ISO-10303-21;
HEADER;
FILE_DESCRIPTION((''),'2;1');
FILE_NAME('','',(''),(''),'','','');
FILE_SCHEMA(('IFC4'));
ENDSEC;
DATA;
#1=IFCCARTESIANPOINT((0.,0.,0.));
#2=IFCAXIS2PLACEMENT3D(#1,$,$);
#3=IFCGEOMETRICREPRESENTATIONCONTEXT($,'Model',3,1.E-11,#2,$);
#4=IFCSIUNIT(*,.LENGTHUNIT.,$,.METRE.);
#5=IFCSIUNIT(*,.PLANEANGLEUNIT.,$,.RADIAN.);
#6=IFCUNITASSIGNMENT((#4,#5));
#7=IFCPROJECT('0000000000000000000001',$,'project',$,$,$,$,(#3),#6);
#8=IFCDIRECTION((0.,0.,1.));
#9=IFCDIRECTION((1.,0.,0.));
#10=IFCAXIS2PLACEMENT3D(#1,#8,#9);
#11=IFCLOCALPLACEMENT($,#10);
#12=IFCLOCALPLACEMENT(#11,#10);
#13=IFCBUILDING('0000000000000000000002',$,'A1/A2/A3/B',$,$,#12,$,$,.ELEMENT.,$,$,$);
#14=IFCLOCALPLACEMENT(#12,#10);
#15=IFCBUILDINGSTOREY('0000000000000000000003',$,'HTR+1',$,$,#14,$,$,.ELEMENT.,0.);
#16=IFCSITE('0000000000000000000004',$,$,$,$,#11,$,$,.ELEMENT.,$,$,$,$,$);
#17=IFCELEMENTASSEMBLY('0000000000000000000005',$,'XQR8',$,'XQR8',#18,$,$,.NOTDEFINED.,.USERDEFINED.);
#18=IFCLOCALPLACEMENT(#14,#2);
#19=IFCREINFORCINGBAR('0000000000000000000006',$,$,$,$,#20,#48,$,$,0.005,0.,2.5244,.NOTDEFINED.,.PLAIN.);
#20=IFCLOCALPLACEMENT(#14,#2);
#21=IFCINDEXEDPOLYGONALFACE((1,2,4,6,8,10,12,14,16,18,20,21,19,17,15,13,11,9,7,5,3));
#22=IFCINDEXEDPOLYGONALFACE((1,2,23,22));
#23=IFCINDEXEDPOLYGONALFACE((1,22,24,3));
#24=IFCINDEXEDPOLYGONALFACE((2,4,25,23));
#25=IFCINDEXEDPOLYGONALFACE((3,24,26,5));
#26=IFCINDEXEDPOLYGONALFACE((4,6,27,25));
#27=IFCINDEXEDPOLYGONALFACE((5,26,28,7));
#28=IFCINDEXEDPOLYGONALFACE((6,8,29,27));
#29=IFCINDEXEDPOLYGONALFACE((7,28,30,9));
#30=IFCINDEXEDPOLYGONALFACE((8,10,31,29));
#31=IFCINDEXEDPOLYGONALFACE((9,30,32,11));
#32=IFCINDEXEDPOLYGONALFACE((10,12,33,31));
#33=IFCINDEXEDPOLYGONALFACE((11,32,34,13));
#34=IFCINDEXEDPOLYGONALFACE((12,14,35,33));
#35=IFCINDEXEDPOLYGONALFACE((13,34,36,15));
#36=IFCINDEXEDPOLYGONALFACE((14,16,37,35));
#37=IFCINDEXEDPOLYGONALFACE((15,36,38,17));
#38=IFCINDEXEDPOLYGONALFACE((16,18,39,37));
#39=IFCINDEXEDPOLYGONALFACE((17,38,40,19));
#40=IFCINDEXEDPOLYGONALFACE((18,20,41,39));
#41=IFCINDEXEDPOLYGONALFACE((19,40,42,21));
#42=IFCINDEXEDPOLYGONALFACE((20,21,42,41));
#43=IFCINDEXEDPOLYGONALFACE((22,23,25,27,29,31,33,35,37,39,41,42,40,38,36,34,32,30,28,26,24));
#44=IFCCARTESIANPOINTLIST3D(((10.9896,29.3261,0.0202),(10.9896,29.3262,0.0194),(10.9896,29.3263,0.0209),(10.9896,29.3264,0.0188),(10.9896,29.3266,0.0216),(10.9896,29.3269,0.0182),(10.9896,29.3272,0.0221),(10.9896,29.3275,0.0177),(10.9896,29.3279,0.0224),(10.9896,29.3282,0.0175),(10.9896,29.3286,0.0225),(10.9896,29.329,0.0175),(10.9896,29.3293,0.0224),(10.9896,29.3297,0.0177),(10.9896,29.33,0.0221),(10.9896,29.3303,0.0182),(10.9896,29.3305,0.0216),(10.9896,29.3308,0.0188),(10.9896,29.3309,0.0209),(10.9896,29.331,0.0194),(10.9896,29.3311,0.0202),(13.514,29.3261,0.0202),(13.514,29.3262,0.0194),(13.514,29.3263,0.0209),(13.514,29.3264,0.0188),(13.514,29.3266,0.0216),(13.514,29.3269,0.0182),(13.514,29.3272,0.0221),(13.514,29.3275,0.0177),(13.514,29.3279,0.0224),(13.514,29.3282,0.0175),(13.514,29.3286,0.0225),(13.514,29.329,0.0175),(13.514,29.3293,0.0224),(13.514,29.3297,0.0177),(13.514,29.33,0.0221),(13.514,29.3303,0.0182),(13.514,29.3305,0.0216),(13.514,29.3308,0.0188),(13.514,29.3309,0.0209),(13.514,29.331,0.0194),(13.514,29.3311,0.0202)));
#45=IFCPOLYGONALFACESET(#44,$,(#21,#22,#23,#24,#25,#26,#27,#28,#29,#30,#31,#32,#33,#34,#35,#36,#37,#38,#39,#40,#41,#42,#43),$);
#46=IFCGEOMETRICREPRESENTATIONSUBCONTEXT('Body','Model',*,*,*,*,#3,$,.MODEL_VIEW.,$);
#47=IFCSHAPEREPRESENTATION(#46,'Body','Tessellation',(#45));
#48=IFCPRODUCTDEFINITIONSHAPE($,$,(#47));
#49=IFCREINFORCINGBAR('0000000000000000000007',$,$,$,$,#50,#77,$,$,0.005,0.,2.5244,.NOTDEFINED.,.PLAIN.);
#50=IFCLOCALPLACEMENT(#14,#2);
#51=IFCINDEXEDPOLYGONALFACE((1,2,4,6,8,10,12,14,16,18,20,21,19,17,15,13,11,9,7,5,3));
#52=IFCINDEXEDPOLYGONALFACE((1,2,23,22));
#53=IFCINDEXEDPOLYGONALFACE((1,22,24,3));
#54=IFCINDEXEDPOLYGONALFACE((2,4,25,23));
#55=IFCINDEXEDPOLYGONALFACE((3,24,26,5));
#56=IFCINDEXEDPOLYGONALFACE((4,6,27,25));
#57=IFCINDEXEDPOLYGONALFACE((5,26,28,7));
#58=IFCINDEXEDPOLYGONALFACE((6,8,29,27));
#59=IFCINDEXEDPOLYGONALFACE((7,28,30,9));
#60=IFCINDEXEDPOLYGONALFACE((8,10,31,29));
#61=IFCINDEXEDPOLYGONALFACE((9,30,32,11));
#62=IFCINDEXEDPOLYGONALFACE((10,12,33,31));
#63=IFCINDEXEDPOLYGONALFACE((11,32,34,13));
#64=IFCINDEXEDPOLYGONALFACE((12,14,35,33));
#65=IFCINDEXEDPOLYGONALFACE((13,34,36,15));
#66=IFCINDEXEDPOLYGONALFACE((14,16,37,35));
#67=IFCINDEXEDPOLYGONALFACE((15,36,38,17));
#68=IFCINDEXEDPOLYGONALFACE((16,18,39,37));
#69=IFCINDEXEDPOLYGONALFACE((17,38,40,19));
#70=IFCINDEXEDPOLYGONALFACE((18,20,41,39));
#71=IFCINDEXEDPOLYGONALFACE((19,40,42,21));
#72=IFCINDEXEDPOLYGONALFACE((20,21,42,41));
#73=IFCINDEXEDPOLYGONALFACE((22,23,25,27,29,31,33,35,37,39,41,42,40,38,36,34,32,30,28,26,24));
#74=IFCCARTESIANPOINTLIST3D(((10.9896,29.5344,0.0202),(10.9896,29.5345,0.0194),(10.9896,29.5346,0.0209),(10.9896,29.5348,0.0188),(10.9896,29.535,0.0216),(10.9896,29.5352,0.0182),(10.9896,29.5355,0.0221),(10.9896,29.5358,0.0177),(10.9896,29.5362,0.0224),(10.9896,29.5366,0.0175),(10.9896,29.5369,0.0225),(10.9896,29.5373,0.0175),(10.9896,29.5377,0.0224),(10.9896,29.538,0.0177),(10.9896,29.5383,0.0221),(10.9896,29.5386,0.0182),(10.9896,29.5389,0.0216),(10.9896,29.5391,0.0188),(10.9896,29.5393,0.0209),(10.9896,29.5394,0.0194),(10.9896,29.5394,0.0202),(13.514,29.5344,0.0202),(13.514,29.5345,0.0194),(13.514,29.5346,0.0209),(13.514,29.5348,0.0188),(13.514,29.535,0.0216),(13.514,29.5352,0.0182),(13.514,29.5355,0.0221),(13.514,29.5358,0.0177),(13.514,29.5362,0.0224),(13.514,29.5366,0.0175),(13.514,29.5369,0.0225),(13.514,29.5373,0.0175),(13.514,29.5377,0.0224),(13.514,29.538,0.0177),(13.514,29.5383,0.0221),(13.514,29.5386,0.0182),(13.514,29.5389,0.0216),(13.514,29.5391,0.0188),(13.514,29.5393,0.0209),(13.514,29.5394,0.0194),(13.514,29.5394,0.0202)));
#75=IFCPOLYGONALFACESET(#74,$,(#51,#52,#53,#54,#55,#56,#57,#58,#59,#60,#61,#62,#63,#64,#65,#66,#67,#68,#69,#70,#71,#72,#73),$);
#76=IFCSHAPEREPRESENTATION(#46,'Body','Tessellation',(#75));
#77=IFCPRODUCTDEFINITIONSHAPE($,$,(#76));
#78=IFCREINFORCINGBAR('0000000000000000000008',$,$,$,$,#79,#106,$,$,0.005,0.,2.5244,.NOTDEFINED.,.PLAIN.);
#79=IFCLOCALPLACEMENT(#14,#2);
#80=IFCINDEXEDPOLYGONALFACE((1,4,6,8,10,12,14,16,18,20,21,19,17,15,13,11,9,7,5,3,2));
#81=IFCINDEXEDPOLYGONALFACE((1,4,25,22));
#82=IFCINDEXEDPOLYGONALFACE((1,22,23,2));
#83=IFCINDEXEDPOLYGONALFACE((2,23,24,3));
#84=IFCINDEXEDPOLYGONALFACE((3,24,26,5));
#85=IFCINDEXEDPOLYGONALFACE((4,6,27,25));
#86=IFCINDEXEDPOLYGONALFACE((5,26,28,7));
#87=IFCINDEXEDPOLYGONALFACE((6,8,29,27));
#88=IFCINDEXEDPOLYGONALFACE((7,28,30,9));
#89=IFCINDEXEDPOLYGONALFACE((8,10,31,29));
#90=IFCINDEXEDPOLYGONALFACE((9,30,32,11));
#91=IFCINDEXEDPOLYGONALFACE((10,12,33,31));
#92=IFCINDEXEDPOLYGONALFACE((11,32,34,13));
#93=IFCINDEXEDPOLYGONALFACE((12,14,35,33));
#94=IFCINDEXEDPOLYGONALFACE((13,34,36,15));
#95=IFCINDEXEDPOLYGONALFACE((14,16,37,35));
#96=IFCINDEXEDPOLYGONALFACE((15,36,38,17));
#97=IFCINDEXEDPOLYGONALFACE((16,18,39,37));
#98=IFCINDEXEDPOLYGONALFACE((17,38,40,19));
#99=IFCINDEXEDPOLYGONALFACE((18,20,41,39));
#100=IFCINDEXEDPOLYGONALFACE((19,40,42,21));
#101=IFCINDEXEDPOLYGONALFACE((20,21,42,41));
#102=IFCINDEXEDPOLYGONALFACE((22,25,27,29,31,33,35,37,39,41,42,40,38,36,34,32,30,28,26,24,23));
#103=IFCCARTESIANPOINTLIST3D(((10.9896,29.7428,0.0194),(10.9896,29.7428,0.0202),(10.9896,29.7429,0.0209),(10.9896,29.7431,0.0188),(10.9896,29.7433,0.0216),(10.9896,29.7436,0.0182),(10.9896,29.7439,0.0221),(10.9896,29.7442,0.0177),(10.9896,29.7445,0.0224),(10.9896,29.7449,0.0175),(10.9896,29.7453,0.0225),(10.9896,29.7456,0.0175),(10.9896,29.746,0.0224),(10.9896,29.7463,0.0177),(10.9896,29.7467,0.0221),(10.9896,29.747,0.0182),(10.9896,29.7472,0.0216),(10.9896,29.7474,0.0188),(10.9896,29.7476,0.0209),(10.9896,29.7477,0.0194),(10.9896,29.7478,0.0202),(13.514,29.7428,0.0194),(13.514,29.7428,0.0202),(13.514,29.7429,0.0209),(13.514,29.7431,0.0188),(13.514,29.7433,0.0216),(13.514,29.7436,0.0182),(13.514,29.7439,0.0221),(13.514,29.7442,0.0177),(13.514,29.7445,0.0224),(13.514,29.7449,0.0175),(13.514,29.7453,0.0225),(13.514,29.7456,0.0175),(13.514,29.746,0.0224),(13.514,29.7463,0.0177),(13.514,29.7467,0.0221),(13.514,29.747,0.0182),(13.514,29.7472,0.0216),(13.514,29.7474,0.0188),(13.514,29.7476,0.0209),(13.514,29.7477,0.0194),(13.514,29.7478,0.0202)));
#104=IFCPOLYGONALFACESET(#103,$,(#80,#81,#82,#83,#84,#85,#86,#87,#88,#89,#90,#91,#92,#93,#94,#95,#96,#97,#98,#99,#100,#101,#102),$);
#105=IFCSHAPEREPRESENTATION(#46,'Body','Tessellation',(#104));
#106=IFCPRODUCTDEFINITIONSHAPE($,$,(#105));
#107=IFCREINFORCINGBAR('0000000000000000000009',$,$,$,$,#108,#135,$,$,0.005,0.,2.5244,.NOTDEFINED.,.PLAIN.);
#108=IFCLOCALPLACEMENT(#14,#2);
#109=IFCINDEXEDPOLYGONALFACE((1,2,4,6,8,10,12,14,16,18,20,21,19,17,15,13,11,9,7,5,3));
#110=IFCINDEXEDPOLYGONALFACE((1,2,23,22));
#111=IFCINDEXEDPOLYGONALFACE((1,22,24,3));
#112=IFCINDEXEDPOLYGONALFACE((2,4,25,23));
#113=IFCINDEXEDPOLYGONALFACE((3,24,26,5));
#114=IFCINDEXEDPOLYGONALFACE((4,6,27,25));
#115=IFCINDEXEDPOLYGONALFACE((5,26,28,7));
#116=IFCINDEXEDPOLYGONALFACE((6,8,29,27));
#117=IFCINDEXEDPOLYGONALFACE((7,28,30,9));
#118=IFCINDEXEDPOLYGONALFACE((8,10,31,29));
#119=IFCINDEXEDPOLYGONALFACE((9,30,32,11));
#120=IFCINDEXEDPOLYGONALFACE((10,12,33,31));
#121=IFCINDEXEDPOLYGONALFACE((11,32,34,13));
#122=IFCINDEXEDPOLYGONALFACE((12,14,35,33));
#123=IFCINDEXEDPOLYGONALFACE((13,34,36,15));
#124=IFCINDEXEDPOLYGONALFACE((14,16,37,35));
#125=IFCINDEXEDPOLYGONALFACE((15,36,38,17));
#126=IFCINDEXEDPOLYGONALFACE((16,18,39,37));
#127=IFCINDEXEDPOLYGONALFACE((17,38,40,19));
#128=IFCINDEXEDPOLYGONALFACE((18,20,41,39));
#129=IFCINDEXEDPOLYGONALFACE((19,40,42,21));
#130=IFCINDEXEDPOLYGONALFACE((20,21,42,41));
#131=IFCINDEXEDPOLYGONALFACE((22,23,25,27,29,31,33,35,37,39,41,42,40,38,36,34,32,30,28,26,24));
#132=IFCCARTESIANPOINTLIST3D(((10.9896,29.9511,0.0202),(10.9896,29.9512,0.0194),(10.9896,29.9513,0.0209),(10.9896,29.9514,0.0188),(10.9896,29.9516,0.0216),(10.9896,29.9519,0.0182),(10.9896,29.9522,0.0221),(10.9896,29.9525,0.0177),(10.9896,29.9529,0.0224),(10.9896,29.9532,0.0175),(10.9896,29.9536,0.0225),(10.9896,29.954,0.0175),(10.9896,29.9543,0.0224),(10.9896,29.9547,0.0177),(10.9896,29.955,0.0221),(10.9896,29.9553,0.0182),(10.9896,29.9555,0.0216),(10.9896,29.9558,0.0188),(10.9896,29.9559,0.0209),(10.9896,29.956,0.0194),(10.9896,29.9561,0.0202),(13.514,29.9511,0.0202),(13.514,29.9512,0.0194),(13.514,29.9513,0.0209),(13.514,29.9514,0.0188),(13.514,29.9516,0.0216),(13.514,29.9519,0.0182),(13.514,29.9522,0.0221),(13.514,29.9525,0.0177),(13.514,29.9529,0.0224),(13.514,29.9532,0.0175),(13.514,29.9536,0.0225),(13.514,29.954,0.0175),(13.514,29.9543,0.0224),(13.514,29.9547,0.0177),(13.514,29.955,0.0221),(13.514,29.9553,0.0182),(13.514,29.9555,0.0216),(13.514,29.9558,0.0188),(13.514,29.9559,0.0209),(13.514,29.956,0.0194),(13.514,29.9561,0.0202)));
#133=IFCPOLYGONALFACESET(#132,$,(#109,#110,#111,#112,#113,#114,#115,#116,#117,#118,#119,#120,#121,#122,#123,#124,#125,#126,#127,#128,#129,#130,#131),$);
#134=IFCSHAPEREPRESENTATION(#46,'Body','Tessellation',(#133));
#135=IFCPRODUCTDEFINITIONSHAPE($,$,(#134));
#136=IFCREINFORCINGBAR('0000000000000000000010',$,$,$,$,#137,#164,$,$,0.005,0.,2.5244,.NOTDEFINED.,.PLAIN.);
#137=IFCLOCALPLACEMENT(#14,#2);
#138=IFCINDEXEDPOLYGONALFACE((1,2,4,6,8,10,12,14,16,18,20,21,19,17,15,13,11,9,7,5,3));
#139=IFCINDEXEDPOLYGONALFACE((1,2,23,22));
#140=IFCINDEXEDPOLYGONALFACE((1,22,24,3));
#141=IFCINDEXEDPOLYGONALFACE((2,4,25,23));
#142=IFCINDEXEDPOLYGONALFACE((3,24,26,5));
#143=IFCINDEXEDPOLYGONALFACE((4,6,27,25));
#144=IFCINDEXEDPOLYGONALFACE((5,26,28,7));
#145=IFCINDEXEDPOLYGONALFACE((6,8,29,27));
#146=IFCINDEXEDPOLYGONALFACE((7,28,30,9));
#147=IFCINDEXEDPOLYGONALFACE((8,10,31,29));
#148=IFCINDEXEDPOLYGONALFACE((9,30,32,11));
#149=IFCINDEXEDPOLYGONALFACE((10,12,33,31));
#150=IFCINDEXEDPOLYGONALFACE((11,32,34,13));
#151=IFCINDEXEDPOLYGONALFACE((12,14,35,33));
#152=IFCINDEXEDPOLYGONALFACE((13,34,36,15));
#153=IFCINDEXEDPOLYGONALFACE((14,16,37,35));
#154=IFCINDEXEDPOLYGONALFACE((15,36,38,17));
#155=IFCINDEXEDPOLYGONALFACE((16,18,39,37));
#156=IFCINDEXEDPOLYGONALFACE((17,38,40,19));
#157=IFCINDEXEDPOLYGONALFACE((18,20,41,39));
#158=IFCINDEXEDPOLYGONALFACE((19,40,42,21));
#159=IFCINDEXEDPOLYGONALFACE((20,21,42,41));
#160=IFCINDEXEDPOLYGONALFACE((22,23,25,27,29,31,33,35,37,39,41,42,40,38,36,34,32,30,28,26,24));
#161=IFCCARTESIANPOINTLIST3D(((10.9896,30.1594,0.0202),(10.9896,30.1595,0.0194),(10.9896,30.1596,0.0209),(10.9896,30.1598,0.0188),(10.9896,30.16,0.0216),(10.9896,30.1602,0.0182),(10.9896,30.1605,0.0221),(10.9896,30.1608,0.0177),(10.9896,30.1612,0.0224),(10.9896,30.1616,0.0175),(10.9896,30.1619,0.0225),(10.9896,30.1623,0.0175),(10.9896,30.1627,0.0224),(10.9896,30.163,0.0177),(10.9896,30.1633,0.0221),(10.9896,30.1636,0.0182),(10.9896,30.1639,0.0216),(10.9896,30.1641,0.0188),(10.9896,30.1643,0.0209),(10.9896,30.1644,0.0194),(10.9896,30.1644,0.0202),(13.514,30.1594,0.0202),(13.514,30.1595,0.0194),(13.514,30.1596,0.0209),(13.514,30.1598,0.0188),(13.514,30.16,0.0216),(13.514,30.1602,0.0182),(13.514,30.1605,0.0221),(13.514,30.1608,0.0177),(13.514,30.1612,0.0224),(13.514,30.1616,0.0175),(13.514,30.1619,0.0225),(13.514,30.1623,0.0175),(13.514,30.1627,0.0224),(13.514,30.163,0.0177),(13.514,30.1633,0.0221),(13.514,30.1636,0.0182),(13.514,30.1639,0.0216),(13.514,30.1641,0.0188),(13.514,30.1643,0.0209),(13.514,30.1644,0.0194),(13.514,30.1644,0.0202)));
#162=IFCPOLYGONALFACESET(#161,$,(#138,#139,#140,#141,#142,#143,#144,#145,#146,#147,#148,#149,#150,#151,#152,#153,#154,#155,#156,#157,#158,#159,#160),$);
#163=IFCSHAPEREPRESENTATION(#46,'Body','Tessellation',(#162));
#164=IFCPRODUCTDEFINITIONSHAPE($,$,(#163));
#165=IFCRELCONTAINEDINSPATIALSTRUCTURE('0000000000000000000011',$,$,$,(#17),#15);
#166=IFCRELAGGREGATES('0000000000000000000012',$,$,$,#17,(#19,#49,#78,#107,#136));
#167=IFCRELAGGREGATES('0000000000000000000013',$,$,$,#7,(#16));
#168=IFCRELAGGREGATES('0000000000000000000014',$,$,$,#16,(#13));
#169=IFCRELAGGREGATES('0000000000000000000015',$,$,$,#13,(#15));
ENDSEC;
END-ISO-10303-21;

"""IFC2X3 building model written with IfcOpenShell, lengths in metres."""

from ifc_helpers import new_model, entity, si_unit, origin, origin_with_axes, place, context, subcontext, project, spatial, shape, element, aggregate, save


model = new_model("IFC2X3")

# Units and contexts
model_context = context("Model", 3, precision=1e-11, world=origin())
body_context = subcontext(model_context, "Body", "Model", "MODEL_VIEW")
ifc_project = project(units=[si_unit("LENGTHUNIT", "METRE"), si_unit("PLANEANGLEUNIT", "RADIAN")], contexts=[model_context])

# Site, building, storey
site_placement = place(None, origin_with_axes())
site = spatial("IfcSite", under=ifc_project, at=site_placement, CompositionType="ELEMENT")
building_placement = place(site_placement, origin_with_axes())
building = spatial("IfcBuilding", under=site, at=building_placement, Name="A1/A2/A3/B", CompositionType="ELEMENT")
storey_placement = place(building_placement, origin_with_axes())
storey = spatial("IfcBuildingStorey", under=building, at=storey_placement, Name="HTR+1", CompositionType="ELEMENT", Elevation=0.0)

# Element assembly, reinforcing bars
assembly_1_placement = place(storey_placement, origin_with_axes())
assembly_1 = element("IfcElementAssembly", 1, at=assembly_1_placement, inside=storey, Name="XQR8", ObjectType="XQR8", AssemblyPlace="NOTDEFINED", PredefinedType="USERDEFINED")
reinforcing_bar_1_placement = place(assembly_1_placement, origin_with_axes())
reinforcing_bar_1 = element("IfcReinforcingBar", 2, at=reinforcing_bar_1_placement, BarLength=2.5244, BarRole="NOTDEFINED", BarSurface="PLAIN", CrossSectionArea=0.0, NominalDiameter=0.005, shapes=[
    shape(body_context, "Body", "AdvancedSweptSolid", [entity("IfcSweptDiskSolid", entity("IfcPolyline", [entity("IfcCartesianPoint", [10.9896, 29.3286, 0.02]), entity("IfcCartesianPoint", [13.514, 29.3286, 0.02])]), 0.0025, None, 0.0, 2.5244)]),
    shape(body_context, "Body", "AdvancedSweptSolid", [entity("IfcSweptDiskSolid", entity("IfcPolyline", [entity("IfcCartesianPoint", [10.9896, 29.3286, 0.02]), entity("IfcCartesianPoint", [13.514, 29.3286, 0.02])]), 0.0025, None, 0.0, 2.5244)]),
])
reinforcing_bar_2_placement = place(assembly_1_placement, origin_with_axes())
reinforcing_bar_2 = element("IfcReinforcingBar", 3, at=reinforcing_bar_2_placement, BarLength=2.5244, BarRole="NOTDEFINED", BarSurface="PLAIN", CrossSectionArea=0.0, NominalDiameter=0.005, shapes=[
    shape(body_context, "Body", "AdvancedSweptSolid", [entity("IfcSweptDiskSolid", entity("IfcPolyline", [entity("IfcCartesianPoint", [10.9896, 29.5369, 0.02]), entity("IfcCartesianPoint", [13.514, 29.5369, 0.02])]), 0.0025, None, 0.0, 2.5244)]),
    shape(body_context, "Body", "AdvancedSweptSolid", [entity("IfcSweptDiskSolid", entity("IfcPolyline", [entity("IfcCartesianPoint", [10.9896, 29.5369, 0.02]), entity("IfcCartesianPoint", [13.514, 29.5369, 0.02])]), 0.0025, None, 0.0, 2.5244)]),
])
reinforcing_bar_3_placement = place(assembly_1_placement, origin_with_axes())
reinforcing_bar_3 = element("IfcReinforcingBar", 4, at=reinforcing_bar_3_placement, BarLength=2.5244, BarRole="NOTDEFINED", BarSurface="PLAIN", CrossSectionArea=0.0, NominalDiameter=0.005, shapes=[
    shape(body_context, "Body", "AdvancedSweptSolid", [entity("IfcSweptDiskSolid", entity("IfcPolyline", [entity("IfcCartesianPoint", [10.9896, 29.7453, 0.02]), entity("IfcCartesianPoint", [13.514, 29.7453, 0.02])]), 0.0025, None, 0.0, 2.5244)]),
    shape(body_context, "Body", "AdvancedSweptSolid", [entity("IfcSweptDiskSolid", entity("IfcPolyline", [entity("IfcCartesianPoint", [10.9896, 29.7453, 0.02]), entity("IfcCartesianPoint", [13.514, 29.7453, 0.02])]), 0.0025, None, 0.0, 2.5244)]),
])
reinforcing_bar_4_placement = place(assembly_1_placement, origin_with_axes())
reinforcing_bar_4 = element("IfcReinforcingBar", 5, at=reinforcing_bar_4_placement, BarLength=2.5244, BarRole="NOTDEFINED", BarSurface="PLAIN", CrossSectionArea=0.0, NominalDiameter=0.005, shapes=[
    shape(body_context, "Body", "AdvancedSweptSolid", [entity("IfcSweptDiskSolid", entity("IfcPolyline", [entity("IfcCartesianPoint", [10.9896, 29.9536, 0.02]), entity("IfcCartesianPoint", [13.514, 29.9536, 0.02])]), 0.0025, None, 0.0, 2.5244)]),
    shape(body_context, "Body", "AdvancedSweptSolid", [entity("IfcSweptDiskSolid", entity("IfcPolyline", [entity("IfcCartesianPoint", [10.9896, 29.9536, 0.02]), entity("IfcCartesianPoint", [13.514, 29.9536, 0.02])]), 0.0025, None, 0.0, 2.5244)]),
])
reinforcing_bar_5_placement = place(assembly_1_placement, origin_with_axes())
reinforcing_bar_5 = element("IfcReinforcingBar", 6, at=reinforcing_bar_5_placement, BarLength=2.5244, BarRole="NOTDEFINED", BarSurface="PLAIN", CrossSectionArea=0.0, NominalDiameter=0.005, shapes=[
    shape(body_context, "Body", "AdvancedSweptSolid", [entity("IfcSweptDiskSolid", entity("IfcPolyline", [entity("IfcCartesianPoint", [10.9896, 30.1619, 0.02]), entity("IfcCartesianPoint", [13.514, 30.1619, 0.02])]), 0.0025, None, 0.0, 2.5244)]),
    shape(body_context, "Body", "AdvancedSweptSolid", [entity("IfcSweptDiskSolid", entity("IfcPolyline", [entity("IfcCartesianPoint", [10.9896, 30.1619, 0.02]), entity("IfcCartesianPoint", [13.514, 30.1619, 0.02])]), 0.0025, None, 0.0, 2.5244)]),
])
aggregate(assembly_1, [reinforcing_bar_1, reinforcing_bar_2, reinforcing_bar_3, reinforcing_bar_4, reinforcing_bar_5])

save(model, "model.ifc")
